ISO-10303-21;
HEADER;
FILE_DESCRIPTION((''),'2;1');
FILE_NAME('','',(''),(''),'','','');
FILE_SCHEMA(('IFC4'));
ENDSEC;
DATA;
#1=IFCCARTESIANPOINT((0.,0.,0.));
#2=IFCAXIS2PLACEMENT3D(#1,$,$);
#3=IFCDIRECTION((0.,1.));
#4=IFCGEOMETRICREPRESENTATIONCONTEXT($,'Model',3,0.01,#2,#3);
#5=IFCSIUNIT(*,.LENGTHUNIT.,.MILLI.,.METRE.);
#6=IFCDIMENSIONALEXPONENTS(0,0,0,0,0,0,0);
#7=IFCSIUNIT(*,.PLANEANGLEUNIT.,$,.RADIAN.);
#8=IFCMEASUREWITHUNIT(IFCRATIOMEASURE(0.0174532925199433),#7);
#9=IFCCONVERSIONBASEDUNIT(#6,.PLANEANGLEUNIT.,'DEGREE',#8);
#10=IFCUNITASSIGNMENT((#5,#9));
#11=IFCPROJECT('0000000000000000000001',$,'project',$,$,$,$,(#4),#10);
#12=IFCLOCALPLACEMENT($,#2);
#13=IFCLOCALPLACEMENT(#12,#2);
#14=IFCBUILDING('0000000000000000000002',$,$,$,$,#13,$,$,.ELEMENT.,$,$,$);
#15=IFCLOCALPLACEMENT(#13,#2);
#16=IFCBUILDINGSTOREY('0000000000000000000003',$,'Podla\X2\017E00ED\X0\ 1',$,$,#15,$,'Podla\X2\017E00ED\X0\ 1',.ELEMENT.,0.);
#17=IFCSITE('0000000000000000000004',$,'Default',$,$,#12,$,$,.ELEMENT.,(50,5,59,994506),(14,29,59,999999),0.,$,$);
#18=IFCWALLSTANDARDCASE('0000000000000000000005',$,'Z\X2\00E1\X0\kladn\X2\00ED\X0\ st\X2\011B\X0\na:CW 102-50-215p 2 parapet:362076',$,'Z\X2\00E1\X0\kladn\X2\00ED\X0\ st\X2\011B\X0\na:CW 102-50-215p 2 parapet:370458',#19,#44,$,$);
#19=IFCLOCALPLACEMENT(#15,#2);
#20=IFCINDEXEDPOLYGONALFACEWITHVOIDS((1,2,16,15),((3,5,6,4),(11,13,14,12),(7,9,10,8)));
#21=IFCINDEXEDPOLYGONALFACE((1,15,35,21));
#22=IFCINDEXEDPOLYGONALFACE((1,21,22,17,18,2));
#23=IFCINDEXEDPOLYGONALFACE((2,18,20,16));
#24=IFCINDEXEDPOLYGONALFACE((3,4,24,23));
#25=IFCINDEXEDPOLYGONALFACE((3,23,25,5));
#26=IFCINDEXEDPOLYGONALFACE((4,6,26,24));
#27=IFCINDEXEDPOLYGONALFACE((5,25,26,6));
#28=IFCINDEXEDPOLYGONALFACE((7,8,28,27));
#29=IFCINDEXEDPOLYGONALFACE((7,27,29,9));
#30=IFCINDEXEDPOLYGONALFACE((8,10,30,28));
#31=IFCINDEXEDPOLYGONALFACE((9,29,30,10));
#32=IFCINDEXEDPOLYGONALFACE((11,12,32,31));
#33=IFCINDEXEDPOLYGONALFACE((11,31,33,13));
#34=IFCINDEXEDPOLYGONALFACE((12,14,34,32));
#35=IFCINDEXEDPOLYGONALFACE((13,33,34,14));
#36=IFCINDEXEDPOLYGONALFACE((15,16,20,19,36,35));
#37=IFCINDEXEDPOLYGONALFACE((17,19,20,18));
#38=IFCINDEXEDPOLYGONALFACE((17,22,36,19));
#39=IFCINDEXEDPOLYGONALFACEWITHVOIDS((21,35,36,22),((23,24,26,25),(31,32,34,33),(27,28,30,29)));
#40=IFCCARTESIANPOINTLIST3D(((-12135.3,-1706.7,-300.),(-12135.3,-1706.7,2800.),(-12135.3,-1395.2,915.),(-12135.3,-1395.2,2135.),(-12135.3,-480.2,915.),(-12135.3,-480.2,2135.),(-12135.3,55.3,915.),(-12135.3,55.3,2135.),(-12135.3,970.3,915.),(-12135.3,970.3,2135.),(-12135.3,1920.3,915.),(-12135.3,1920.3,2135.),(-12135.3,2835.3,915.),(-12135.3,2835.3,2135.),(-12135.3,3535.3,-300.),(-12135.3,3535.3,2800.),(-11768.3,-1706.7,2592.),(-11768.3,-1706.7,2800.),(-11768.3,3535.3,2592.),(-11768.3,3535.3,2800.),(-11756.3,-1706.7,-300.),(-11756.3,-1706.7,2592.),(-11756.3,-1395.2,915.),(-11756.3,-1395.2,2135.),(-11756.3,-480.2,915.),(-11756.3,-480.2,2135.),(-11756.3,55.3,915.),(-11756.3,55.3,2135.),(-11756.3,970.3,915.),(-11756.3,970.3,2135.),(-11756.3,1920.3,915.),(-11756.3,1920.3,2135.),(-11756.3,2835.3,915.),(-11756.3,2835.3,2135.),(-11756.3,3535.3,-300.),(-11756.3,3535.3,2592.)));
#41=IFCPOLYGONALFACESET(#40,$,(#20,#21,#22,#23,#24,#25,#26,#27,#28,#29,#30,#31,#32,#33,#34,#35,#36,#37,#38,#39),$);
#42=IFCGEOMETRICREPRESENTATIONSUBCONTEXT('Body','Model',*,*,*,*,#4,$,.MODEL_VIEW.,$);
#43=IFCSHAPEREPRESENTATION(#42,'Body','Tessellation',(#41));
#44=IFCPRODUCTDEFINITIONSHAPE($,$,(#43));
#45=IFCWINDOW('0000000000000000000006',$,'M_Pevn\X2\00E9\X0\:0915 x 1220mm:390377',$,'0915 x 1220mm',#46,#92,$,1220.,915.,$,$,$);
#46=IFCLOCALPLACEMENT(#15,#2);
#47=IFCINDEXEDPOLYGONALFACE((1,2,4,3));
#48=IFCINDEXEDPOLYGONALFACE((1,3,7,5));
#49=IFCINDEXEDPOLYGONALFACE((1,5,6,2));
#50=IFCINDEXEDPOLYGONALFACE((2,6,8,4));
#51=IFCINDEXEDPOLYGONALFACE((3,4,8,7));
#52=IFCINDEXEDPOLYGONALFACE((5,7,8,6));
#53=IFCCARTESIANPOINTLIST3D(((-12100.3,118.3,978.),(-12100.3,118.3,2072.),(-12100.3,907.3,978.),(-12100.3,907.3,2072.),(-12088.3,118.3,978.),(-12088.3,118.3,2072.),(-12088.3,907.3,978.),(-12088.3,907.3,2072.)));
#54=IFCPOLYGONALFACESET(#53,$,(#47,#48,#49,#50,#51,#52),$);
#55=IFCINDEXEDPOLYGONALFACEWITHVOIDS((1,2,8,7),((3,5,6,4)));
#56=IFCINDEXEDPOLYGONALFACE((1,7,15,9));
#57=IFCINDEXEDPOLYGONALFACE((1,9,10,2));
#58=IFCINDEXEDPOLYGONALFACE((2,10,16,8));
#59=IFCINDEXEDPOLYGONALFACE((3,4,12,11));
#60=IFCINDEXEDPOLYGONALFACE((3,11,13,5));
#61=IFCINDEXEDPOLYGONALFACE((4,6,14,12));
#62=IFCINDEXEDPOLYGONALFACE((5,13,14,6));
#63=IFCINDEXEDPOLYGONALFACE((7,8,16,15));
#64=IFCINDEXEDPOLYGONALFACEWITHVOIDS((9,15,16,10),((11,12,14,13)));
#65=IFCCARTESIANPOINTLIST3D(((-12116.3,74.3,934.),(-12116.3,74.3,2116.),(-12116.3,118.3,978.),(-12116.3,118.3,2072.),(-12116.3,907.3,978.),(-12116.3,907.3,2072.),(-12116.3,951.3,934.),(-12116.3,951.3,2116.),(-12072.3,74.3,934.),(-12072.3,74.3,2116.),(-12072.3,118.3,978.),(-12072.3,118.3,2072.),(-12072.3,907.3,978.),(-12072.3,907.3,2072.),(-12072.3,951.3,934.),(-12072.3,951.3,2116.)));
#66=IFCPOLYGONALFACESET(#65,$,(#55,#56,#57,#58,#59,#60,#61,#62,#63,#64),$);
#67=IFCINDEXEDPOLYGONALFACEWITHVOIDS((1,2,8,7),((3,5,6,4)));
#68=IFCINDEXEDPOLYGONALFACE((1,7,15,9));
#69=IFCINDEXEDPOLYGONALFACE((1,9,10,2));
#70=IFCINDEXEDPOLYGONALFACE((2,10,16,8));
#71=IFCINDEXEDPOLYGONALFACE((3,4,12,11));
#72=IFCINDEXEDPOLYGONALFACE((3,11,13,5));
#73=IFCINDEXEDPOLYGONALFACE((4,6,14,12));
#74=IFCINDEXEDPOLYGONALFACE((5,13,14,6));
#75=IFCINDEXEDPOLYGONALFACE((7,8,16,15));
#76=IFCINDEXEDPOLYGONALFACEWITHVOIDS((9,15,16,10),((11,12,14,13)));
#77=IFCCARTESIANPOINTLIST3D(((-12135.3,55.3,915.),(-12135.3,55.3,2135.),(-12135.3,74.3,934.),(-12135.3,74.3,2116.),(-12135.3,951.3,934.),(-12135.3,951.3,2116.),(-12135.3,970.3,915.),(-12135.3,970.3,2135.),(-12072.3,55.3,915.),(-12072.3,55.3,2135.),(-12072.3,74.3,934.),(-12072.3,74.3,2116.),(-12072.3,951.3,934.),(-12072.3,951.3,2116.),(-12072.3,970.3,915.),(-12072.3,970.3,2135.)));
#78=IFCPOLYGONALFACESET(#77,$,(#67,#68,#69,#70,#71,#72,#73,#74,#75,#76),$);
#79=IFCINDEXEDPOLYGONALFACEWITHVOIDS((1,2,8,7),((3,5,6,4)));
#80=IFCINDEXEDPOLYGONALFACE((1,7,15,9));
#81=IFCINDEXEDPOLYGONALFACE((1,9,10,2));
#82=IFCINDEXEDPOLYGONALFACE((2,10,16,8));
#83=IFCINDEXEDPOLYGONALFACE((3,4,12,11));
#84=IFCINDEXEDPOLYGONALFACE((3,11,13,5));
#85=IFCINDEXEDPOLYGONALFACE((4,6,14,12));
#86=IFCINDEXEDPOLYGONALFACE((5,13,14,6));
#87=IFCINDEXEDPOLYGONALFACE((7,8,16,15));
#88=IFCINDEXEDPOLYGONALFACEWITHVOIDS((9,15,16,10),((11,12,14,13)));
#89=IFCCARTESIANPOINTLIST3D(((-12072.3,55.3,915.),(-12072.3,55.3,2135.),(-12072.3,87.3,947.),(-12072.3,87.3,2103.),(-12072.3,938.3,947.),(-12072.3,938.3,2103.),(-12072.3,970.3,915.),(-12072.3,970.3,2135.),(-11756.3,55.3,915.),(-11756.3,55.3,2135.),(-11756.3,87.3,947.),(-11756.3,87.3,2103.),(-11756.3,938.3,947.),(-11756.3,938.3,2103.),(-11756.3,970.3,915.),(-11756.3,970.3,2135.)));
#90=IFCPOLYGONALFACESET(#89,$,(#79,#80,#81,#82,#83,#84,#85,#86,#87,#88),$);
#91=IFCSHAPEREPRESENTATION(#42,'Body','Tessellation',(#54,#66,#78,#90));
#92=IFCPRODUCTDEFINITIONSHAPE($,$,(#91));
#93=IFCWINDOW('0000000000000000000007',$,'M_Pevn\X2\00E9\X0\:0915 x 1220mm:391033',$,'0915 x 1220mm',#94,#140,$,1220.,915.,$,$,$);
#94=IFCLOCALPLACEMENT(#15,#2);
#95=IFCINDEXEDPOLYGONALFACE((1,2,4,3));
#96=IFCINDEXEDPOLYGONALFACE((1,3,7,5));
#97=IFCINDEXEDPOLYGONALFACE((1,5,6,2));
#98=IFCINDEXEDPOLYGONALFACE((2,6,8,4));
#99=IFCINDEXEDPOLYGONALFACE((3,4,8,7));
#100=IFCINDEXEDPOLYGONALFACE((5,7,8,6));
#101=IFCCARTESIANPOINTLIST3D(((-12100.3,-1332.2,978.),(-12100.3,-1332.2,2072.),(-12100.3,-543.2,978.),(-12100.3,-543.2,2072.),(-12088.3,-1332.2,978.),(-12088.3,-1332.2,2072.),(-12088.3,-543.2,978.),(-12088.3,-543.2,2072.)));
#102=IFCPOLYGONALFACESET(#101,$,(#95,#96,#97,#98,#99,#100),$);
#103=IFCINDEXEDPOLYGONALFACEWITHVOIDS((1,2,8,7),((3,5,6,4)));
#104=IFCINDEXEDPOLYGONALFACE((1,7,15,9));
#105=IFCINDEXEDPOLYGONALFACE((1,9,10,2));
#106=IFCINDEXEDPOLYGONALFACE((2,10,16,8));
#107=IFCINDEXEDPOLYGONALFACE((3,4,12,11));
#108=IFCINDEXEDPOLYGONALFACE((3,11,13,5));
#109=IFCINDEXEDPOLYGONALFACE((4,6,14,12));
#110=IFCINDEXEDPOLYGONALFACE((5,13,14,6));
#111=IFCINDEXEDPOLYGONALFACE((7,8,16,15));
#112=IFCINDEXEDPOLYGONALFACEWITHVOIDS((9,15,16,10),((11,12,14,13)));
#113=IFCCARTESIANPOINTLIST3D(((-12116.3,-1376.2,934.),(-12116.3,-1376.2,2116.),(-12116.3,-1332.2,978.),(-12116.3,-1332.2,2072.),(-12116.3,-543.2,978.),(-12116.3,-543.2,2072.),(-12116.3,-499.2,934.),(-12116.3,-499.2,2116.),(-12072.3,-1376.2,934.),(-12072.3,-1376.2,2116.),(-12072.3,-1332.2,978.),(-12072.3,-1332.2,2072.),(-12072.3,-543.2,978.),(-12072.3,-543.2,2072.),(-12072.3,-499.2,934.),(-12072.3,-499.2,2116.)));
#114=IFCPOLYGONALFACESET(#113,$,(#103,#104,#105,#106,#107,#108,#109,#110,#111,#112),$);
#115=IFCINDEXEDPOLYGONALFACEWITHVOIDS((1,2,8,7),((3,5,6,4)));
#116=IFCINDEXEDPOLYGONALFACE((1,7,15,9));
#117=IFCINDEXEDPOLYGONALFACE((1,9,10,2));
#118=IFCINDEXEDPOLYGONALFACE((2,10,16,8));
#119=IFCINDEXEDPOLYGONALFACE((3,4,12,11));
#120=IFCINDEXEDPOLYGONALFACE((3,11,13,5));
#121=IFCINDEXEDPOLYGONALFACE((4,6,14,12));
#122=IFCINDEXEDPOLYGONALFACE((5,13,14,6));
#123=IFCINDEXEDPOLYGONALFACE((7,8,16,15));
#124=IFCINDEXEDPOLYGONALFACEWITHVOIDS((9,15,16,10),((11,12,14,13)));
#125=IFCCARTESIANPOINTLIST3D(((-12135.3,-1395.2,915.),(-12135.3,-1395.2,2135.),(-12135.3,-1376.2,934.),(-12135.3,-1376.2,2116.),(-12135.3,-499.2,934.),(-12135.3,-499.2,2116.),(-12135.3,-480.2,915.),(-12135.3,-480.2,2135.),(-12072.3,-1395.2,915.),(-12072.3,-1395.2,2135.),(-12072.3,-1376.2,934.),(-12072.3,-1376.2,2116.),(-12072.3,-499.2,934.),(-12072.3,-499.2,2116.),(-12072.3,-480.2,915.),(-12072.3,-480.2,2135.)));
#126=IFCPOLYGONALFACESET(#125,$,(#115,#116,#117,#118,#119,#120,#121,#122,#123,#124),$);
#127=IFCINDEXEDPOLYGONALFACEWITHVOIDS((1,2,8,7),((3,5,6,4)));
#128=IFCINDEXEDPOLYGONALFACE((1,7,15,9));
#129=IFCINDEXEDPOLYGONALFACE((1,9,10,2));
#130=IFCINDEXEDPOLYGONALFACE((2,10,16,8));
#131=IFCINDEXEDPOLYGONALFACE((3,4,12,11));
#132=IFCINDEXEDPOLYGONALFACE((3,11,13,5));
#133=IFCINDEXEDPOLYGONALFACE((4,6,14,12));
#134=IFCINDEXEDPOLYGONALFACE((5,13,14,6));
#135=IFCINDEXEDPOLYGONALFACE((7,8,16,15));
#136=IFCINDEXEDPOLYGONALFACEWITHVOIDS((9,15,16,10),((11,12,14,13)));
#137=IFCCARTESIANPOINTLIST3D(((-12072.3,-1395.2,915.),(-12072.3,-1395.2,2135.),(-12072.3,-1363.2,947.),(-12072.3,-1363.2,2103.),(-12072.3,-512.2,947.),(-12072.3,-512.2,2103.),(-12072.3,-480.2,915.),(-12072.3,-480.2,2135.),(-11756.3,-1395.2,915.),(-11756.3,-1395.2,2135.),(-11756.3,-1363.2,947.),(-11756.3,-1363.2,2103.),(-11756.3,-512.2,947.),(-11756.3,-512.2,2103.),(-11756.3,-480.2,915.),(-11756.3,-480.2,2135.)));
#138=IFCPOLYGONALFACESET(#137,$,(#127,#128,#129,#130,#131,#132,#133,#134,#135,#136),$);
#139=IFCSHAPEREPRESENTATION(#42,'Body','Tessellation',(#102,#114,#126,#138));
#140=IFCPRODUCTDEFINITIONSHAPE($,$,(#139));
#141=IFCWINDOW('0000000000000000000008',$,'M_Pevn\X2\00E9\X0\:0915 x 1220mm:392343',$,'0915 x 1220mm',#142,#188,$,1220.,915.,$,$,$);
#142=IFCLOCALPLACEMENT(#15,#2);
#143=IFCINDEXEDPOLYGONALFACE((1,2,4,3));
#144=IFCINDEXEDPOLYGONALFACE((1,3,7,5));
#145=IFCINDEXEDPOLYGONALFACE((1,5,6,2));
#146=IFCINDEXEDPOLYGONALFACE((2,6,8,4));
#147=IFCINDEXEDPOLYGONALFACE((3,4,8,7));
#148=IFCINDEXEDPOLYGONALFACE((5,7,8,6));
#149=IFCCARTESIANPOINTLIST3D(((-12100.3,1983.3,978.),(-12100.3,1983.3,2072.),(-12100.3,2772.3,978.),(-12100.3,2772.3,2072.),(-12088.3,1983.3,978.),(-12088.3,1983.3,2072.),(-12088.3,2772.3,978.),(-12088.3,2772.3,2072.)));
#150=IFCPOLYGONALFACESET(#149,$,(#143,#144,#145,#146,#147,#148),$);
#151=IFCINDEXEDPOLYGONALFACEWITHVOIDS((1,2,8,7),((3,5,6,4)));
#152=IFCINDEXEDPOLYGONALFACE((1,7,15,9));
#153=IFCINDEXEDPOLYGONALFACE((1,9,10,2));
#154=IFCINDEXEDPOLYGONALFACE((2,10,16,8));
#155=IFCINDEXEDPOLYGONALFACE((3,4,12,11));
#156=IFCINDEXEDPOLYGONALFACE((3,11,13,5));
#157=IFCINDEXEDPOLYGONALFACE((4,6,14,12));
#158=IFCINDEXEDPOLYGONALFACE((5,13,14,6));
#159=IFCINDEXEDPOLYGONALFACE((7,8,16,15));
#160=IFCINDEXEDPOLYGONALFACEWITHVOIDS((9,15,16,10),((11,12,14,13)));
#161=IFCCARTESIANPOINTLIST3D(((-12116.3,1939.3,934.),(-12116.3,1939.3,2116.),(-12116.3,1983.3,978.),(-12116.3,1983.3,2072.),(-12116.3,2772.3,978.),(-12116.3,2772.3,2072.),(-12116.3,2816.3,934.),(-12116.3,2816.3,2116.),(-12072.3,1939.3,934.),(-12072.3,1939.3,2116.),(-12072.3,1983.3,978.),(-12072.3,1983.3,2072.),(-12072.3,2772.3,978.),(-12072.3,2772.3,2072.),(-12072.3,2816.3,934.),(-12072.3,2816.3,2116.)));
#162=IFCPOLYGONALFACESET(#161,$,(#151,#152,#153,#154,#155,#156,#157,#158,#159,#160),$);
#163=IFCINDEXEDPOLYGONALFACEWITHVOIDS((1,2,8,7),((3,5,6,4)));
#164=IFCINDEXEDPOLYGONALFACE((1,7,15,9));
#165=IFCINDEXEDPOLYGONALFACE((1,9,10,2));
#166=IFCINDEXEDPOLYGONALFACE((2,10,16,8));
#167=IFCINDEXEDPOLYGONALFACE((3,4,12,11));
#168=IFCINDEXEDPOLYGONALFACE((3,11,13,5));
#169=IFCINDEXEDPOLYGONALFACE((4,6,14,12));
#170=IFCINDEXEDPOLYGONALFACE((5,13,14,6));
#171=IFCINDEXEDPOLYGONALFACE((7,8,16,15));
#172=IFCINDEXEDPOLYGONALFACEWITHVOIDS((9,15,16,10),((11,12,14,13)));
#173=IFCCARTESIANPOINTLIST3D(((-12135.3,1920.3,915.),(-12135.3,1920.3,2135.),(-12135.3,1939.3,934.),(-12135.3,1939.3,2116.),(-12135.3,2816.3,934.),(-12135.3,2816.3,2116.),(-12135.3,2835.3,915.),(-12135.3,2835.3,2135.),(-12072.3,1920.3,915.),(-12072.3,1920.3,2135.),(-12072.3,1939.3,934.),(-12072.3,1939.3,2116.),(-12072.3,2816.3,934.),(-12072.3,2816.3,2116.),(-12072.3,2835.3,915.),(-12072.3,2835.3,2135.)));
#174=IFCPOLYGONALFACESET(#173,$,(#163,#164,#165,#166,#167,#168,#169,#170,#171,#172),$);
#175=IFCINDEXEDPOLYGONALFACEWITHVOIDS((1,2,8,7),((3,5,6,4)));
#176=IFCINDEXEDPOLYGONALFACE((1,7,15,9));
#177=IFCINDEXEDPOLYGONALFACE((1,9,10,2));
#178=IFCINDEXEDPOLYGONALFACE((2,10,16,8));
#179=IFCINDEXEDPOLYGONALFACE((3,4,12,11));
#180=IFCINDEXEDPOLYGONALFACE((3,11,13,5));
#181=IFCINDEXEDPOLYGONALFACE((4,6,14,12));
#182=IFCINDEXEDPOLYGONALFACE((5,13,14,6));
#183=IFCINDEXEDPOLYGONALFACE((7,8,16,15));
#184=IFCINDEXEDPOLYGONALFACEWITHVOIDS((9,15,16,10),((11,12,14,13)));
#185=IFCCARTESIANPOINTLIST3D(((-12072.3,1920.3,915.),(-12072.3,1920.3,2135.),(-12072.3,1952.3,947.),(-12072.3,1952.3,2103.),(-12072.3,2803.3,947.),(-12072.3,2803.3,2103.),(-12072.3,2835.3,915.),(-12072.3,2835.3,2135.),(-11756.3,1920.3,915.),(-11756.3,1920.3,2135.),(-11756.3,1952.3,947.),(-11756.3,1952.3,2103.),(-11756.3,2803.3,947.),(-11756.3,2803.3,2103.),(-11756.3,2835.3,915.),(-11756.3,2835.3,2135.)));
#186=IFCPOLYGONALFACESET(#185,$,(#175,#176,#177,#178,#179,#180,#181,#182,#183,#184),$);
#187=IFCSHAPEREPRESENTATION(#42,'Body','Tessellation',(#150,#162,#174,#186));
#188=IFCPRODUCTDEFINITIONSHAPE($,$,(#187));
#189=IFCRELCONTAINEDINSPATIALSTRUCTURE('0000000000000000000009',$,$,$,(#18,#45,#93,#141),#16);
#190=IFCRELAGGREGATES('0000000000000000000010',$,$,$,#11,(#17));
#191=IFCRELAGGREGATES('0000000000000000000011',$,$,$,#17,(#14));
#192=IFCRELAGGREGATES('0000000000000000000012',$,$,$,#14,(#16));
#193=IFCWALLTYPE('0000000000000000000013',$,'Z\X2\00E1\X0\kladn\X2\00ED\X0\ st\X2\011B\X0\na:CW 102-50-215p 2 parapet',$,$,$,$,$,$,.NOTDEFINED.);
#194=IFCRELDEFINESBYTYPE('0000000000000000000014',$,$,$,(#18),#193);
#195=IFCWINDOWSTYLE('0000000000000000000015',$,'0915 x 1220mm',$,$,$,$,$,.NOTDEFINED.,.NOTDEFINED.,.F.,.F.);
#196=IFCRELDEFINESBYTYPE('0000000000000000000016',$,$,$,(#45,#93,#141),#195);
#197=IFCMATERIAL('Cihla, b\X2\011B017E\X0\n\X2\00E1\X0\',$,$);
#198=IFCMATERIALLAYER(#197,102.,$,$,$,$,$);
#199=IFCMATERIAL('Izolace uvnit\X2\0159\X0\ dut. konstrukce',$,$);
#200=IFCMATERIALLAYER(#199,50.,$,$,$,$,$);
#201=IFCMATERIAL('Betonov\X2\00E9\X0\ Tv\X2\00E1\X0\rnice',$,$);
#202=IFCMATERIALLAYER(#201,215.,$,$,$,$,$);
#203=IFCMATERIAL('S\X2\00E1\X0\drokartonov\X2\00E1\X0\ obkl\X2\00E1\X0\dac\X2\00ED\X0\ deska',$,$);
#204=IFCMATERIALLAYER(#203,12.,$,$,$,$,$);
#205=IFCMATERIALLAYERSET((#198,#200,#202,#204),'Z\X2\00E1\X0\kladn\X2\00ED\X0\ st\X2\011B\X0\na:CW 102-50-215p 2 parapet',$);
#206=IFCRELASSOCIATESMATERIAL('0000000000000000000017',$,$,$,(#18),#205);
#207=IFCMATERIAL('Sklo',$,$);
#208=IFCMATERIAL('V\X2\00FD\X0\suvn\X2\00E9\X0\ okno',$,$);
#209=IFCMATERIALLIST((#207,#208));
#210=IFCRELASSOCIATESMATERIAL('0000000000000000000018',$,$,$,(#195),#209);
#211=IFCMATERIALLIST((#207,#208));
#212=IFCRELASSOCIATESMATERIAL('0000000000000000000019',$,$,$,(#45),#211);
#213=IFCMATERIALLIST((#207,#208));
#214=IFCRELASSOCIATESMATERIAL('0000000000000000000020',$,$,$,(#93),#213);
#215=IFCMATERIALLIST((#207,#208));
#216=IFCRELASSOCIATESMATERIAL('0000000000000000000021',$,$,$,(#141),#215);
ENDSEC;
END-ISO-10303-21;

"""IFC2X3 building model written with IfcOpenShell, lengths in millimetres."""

from ifc_helpers import new_model, entity, si_unit, converted_unit, direction, frame, frame_2d, origin, origin_2d_with_axis, place, context, subcontext, project, spatial, polyline, rectangle, outline, extrude, clip, halfspace, bounded_halfspace, source, transform, mapped, material, material_list, layer, layer_set, layer_usage, type_object, type_shapes, element, fill, save


model = new_model("IFC2X3")

# Units and contexts
model_context = context("Model", 3, precision=0.01, world=origin(), true_north=direction((0.0, 1.0)))
body_context = subcontext(model_context, "Body", "Model", "MODEL_VIEW")
ifc_project = project(units=[si_unit("LENGTHUNIT", "METRE", prefix="MILLI"), converted_unit("PLANEANGLEUNIT", "DEGREE", entity("IfcRatioMeasure", 0.0174532925199433), si_unit("PLANEANGLEUNIT", "RADIAN"), dimensions=[0, 0, 0, 0, 0, 0, 0])], contexts=[model_context])

# Site, building, storey
site_placement = place(None, origin())
site = spatial("IfcSite", under=ifc_project, at=site_placement, Name="Default", CompositionType="ELEMENT", RefLatitude=(50, 5, 59, 994506), RefLongitude=(14, 29, 59, 999999), RefElevation=0.0)
building_placement = place(site_placement, origin())
building = spatial("IfcBuilding", under=site, at=building_placement, CompositionType="ELEMENT")
storey_placement = place(building_placement, origin())
storey = spatial("IfcBuildingStorey", under=building, at=storey_placement, Name="Podlaží 1", LongName="Podlaží 1", CompositionType="ELEMENT", Elevation=0.0)

# Wall, openings, windows
ifc_material_1 = material(Name="Cihla, běžná")
ifc_layer_1 = layer(ifc_material_1, 102.0)
ifc_material_2 = material(Name="Izolace uvnitř dut. konstrukce")
ifc_layer_2 = layer(ifc_material_2, 50.0)
ifc_material_3 = material(Name="Betonové Tvárnice")
ifc_layer_3 = layer(ifc_material_3, 215.0)
ifc_material_4 = material(Name="Sádrokartonová obkládací deska")
ifc_layer_4 = layer(ifc_material_4, 12.0)
ifc_layer_set_1 = layer_set([ifc_layer_1, ifc_layer_2, ifc_layer_3, ifc_layer_4], Name="Základní stěna:CW 102-50-215p 2 parapet")
ifc_layer_usage_1 = layer_usage(ifc_layer_set_1, "AXIS2", "POSITIVE", -189.5)
wall_type_1 = type_object("IfcWallType", Name="Základní stěna:CW 102-50-215p 2 parapet", PredefinedType="NOTDEFINED")
wall_1_placement = place(storey_placement, frame((-11945.8, 3535.3, -300.0), z_axis=(0.0, 0.0, 1.0), x_axis=(0.0, -1.0, 0.0)))
wall_1 = element("IfcWallStandardCase", 1, at=wall_1_placement, inside=storey, type_object=wall_type_1, material=ifc_layer_usage_1, Name="Základní stěna:CW 102-50-215p 2 parapet:362076", ObjectType="Základní stěna:CW 102-50-215p 2 parapet:370458", context=body_context, shape_type="Clipping", body=[
    clip(clip(clip(extrude(rectangle(XDim=5242.0, YDim=379.0, at=frame_2d((2621.0, 0.0), x_axis=(-1.0, 0.0))), origin(), (0.0, 0.0, 1.0), 3100.0), bounded_halfspace(frame((0.0, 177.5, 2892.0), z_axis=(0.0, 0.0, -1.0), x_axis=(0.0, 1.0, 0.0)), True, frame((0.0, 177.5, 2892.0), z_axis=(0.0, 0.0, -1.0), x_axis=(0.0, 1.0, 0.0)), polyline([(0.0, 0.0), (12.0, 0.0), (12.0, 5242.0), (0.0, 5242.0), (0.0, 0.0)]))), bounded_halfspace(frame((5242.0, 177.5, 2892.0), z_axis=(0.0, -1.0, 0.0), x_axis=(0.0, 0.0, 1.0)), True, frame((5242.0, 177.5, 2892.0), z_axis=(0.0, -1.0, 0.0), x_axis=(0.0, 0.0, 1.0)), polyline([(0.0, 0.0), (208.0, 0.0), (208.0, 5242.0), (0.0, 5242.0), (0.0, 0.0)]))), halfspace(frame((0.0, 0.0, -300.0)), True)),
])
opening_1_placement = place(wall_1_placement, frame((3480.0, 189.5, 1215.0)))
opening_1 = element("IfcOpeningElement", 2, at=opening_1_placement, cuts=wall_1, ObjectType="Opening", context=body_context, shape_type="SweptSolid", body=[
    extrude(rectangle(XDim=1220.0, YDim=915.0, at=frame_2d((610.0, 457.5), x_axis=(1.0, 0.0))), frame((0.0, 0.0, 0.0), z_axis=(0.0, -1.0, 0.0), x_axis=(0.0, 0.0, 1.0)), (0.0, 0.0, 1.0), 379.0),
])
opening_2_placement = place(wall_1_placement, frame((4930.5, 189.5, 1215.0)))
opening_2 = element("IfcOpeningElement", 3, at=opening_2_placement, cuts=wall_1, ObjectType="Opening", context=body_context, shape_type="SweptSolid", body=[
    extrude(rectangle(XDim=1220.0, YDim=915.0, at=frame_2d((610.0, 457.5), x_axis=(1.0, 0.0))), frame((0.0, 0.0, 0.0), z_axis=(0.0, -1.0, 0.0), x_axis=(0.0, 0.0, 1.0)), (0.0, 0.0, 1.0), 379.0),
])
opening_3_placement = place(wall_1_placement, frame((1615.0, 189.5, 1215.0)))
opening_3 = element("IfcOpeningElement", 4, at=opening_3_placement, cuts=wall_1, ObjectType="Opening", context=body_context, shape_type="SweptSolid", body=[
    extrude(rectangle(XDim=1220.0, YDim=915.0, at=frame_2d((610.0, 457.5), x_axis=(1.0, 0.0))), frame((0.0, 0.0, 0.0), z_axis=(0.0, -1.0, 0.0), x_axis=(0.0, 0.0, 1.0)), (0.0, 0.0, 1.0), 379.0),
])
ifc_material_5 = material(Name="Sklo")
ifc_material_6 = material(Name="Výsuvné okno")
ifc_material_list_1 = material_list([ifc_material_5, ifc_material_6])
ifc_material_list_2 = material_list([ifc_material_5, ifc_material_6])
window_style = type_object("IfcWindowStyle", Name="0915 x 1220mm", ConstructionType="NOTDEFINED", OperationType="NOTDEFINED", ParameterTakesPrecedence=False, Sizeable=False, material=ifc_material_list_2)
shared_shape_1 = source(origin(), body_context, "Body", "SweptSolid", [
    extrude(rectangle(XDim=12.0, YDim=789.0, at=origin_2d_with_axis()), frame((457.5, 338.0, 63.0), z_axis=(0.0, 0.0, 1.0), x_axis=(0.0, -1.0, 0.0)), (0.0, 0.0, 1.0), 1094.0),
    extrude(outline(polyline([(-438.5, -591.0), (438.5, -591.0), (438.5, 591.0), (-438.5, 591.0), (-438.5, -591.0)]), holes=[polyline([(-394.5, -547.0), (-394.5, 547.0), (394.5, 547.0), (394.5, -547.0), (-394.5, -547.0)])]), frame((457.5, 316.0, 610.0), z_axis=(0.0, 1.0, 0.0), x_axis=(1.0, 0.0, 0.0)), (0.0, 0.0, 1.0), 44.0),
    extrude(outline(polyline([(-457.5, -610.0), (457.5, -610.0), (457.5, 610.0), (-457.5, 610.0), (-457.5, -610.0)]), holes=[polyline([(-438.5, -591.0), (-438.5, 591.0), (438.5, 591.0), (438.5, -591.0), (-438.5, -591.0)])]), frame((457.5, 316.0, 610.0), z_axis=(0.0, 1.0, 0.0), x_axis=(1.0, 0.0, 0.0)), (0.0, 0.0, 1.0), 63.0),
    extrude(outline(polyline([(-457.5, -610.0), (457.5, -610.0), (457.5, 610.0), (-457.5, 610.0), (-457.5, -610.0)]), holes=[polyline([(-425.5, -578.0), (-425.5, 578.0), (425.5, 578.0), (425.5, -578.0), (-425.5, -578.0)])]), frame((457.5, 0.0, 610.0), z_axis=(0.0, 1.0, 0.0), x_axis=(1.0, 0.0, 0.0)), (0.0, 0.0, 1.0), 316.0),
])
type_shapes(window_style, [shared_shape_1])
window_1_placement = place(opening_1_placement, frame((0.0, 0.0, 0.0), z_axis=(0.0, 0.0, 1.0), x_axis=(-1.0, 0.0, 0.0)))
window_1 = element("IfcWindow", 5, at=window_1_placement, inside=storey, type_object=window_style, material=ifc_material_list_1, Name="M_Pevné:0915 x 1220mm:390377", ObjectType="0915 x 1220mm", OverallHeight=1220.0, OverallWidth=915.0, context=body_context, shape_type="MappedRepresentation", body=[
    mapped(shared_shape_1, transform((0.0, 0.0, 0.0), scale=1.0)),
])
fill(opening_1, window_1)
ifc_material_list_3 = material_list([ifc_material_5, ifc_material_6])
window_2_placement = place(opening_2_placement, frame((0.0, 0.0, 0.0), z_axis=(0.0, 0.0, 1.0), x_axis=(-1.0, 0.0, 0.0)))
window_2 = element("IfcWindow", 6, at=window_2_placement, inside=storey, type_object=window_style, material=ifc_material_list_3, Name="M_Pevné:0915 x 1220mm:391033", ObjectType="0915 x 1220mm", OverallHeight=1220.0, OverallWidth=915.0, context=body_context, shape_type="MappedRepresentation", body=[
    mapped(shared_shape_1, transform((0.0, 0.0, 0.0), scale=1.0)),
])
fill(opening_2, window_2)
ifc_material_list_4 = material_list([ifc_material_5, ifc_material_6])
window_3_placement = place(opening_3_placement, frame((0.0, 0.0, 0.0), z_axis=(0.0, 0.0, 1.0), x_axis=(-1.0, 0.0, 0.0)))
window_3 = element("IfcWindow", 7, at=window_3_placement, inside=storey, type_object=window_style, material=ifc_material_list_4, Name="M_Pevné:0915 x 1220mm:392343", ObjectType="0915 x 1220mm", OverallHeight=1220.0, OverallWidth=915.0, context=body_context, shape_type="MappedRepresentation", body=[
    mapped(shared_shape_1, transform((0.0, 0.0, 0.0), scale=1.0)),
])
fill(opening_3, window_3)

save(model, "model.ifc")
